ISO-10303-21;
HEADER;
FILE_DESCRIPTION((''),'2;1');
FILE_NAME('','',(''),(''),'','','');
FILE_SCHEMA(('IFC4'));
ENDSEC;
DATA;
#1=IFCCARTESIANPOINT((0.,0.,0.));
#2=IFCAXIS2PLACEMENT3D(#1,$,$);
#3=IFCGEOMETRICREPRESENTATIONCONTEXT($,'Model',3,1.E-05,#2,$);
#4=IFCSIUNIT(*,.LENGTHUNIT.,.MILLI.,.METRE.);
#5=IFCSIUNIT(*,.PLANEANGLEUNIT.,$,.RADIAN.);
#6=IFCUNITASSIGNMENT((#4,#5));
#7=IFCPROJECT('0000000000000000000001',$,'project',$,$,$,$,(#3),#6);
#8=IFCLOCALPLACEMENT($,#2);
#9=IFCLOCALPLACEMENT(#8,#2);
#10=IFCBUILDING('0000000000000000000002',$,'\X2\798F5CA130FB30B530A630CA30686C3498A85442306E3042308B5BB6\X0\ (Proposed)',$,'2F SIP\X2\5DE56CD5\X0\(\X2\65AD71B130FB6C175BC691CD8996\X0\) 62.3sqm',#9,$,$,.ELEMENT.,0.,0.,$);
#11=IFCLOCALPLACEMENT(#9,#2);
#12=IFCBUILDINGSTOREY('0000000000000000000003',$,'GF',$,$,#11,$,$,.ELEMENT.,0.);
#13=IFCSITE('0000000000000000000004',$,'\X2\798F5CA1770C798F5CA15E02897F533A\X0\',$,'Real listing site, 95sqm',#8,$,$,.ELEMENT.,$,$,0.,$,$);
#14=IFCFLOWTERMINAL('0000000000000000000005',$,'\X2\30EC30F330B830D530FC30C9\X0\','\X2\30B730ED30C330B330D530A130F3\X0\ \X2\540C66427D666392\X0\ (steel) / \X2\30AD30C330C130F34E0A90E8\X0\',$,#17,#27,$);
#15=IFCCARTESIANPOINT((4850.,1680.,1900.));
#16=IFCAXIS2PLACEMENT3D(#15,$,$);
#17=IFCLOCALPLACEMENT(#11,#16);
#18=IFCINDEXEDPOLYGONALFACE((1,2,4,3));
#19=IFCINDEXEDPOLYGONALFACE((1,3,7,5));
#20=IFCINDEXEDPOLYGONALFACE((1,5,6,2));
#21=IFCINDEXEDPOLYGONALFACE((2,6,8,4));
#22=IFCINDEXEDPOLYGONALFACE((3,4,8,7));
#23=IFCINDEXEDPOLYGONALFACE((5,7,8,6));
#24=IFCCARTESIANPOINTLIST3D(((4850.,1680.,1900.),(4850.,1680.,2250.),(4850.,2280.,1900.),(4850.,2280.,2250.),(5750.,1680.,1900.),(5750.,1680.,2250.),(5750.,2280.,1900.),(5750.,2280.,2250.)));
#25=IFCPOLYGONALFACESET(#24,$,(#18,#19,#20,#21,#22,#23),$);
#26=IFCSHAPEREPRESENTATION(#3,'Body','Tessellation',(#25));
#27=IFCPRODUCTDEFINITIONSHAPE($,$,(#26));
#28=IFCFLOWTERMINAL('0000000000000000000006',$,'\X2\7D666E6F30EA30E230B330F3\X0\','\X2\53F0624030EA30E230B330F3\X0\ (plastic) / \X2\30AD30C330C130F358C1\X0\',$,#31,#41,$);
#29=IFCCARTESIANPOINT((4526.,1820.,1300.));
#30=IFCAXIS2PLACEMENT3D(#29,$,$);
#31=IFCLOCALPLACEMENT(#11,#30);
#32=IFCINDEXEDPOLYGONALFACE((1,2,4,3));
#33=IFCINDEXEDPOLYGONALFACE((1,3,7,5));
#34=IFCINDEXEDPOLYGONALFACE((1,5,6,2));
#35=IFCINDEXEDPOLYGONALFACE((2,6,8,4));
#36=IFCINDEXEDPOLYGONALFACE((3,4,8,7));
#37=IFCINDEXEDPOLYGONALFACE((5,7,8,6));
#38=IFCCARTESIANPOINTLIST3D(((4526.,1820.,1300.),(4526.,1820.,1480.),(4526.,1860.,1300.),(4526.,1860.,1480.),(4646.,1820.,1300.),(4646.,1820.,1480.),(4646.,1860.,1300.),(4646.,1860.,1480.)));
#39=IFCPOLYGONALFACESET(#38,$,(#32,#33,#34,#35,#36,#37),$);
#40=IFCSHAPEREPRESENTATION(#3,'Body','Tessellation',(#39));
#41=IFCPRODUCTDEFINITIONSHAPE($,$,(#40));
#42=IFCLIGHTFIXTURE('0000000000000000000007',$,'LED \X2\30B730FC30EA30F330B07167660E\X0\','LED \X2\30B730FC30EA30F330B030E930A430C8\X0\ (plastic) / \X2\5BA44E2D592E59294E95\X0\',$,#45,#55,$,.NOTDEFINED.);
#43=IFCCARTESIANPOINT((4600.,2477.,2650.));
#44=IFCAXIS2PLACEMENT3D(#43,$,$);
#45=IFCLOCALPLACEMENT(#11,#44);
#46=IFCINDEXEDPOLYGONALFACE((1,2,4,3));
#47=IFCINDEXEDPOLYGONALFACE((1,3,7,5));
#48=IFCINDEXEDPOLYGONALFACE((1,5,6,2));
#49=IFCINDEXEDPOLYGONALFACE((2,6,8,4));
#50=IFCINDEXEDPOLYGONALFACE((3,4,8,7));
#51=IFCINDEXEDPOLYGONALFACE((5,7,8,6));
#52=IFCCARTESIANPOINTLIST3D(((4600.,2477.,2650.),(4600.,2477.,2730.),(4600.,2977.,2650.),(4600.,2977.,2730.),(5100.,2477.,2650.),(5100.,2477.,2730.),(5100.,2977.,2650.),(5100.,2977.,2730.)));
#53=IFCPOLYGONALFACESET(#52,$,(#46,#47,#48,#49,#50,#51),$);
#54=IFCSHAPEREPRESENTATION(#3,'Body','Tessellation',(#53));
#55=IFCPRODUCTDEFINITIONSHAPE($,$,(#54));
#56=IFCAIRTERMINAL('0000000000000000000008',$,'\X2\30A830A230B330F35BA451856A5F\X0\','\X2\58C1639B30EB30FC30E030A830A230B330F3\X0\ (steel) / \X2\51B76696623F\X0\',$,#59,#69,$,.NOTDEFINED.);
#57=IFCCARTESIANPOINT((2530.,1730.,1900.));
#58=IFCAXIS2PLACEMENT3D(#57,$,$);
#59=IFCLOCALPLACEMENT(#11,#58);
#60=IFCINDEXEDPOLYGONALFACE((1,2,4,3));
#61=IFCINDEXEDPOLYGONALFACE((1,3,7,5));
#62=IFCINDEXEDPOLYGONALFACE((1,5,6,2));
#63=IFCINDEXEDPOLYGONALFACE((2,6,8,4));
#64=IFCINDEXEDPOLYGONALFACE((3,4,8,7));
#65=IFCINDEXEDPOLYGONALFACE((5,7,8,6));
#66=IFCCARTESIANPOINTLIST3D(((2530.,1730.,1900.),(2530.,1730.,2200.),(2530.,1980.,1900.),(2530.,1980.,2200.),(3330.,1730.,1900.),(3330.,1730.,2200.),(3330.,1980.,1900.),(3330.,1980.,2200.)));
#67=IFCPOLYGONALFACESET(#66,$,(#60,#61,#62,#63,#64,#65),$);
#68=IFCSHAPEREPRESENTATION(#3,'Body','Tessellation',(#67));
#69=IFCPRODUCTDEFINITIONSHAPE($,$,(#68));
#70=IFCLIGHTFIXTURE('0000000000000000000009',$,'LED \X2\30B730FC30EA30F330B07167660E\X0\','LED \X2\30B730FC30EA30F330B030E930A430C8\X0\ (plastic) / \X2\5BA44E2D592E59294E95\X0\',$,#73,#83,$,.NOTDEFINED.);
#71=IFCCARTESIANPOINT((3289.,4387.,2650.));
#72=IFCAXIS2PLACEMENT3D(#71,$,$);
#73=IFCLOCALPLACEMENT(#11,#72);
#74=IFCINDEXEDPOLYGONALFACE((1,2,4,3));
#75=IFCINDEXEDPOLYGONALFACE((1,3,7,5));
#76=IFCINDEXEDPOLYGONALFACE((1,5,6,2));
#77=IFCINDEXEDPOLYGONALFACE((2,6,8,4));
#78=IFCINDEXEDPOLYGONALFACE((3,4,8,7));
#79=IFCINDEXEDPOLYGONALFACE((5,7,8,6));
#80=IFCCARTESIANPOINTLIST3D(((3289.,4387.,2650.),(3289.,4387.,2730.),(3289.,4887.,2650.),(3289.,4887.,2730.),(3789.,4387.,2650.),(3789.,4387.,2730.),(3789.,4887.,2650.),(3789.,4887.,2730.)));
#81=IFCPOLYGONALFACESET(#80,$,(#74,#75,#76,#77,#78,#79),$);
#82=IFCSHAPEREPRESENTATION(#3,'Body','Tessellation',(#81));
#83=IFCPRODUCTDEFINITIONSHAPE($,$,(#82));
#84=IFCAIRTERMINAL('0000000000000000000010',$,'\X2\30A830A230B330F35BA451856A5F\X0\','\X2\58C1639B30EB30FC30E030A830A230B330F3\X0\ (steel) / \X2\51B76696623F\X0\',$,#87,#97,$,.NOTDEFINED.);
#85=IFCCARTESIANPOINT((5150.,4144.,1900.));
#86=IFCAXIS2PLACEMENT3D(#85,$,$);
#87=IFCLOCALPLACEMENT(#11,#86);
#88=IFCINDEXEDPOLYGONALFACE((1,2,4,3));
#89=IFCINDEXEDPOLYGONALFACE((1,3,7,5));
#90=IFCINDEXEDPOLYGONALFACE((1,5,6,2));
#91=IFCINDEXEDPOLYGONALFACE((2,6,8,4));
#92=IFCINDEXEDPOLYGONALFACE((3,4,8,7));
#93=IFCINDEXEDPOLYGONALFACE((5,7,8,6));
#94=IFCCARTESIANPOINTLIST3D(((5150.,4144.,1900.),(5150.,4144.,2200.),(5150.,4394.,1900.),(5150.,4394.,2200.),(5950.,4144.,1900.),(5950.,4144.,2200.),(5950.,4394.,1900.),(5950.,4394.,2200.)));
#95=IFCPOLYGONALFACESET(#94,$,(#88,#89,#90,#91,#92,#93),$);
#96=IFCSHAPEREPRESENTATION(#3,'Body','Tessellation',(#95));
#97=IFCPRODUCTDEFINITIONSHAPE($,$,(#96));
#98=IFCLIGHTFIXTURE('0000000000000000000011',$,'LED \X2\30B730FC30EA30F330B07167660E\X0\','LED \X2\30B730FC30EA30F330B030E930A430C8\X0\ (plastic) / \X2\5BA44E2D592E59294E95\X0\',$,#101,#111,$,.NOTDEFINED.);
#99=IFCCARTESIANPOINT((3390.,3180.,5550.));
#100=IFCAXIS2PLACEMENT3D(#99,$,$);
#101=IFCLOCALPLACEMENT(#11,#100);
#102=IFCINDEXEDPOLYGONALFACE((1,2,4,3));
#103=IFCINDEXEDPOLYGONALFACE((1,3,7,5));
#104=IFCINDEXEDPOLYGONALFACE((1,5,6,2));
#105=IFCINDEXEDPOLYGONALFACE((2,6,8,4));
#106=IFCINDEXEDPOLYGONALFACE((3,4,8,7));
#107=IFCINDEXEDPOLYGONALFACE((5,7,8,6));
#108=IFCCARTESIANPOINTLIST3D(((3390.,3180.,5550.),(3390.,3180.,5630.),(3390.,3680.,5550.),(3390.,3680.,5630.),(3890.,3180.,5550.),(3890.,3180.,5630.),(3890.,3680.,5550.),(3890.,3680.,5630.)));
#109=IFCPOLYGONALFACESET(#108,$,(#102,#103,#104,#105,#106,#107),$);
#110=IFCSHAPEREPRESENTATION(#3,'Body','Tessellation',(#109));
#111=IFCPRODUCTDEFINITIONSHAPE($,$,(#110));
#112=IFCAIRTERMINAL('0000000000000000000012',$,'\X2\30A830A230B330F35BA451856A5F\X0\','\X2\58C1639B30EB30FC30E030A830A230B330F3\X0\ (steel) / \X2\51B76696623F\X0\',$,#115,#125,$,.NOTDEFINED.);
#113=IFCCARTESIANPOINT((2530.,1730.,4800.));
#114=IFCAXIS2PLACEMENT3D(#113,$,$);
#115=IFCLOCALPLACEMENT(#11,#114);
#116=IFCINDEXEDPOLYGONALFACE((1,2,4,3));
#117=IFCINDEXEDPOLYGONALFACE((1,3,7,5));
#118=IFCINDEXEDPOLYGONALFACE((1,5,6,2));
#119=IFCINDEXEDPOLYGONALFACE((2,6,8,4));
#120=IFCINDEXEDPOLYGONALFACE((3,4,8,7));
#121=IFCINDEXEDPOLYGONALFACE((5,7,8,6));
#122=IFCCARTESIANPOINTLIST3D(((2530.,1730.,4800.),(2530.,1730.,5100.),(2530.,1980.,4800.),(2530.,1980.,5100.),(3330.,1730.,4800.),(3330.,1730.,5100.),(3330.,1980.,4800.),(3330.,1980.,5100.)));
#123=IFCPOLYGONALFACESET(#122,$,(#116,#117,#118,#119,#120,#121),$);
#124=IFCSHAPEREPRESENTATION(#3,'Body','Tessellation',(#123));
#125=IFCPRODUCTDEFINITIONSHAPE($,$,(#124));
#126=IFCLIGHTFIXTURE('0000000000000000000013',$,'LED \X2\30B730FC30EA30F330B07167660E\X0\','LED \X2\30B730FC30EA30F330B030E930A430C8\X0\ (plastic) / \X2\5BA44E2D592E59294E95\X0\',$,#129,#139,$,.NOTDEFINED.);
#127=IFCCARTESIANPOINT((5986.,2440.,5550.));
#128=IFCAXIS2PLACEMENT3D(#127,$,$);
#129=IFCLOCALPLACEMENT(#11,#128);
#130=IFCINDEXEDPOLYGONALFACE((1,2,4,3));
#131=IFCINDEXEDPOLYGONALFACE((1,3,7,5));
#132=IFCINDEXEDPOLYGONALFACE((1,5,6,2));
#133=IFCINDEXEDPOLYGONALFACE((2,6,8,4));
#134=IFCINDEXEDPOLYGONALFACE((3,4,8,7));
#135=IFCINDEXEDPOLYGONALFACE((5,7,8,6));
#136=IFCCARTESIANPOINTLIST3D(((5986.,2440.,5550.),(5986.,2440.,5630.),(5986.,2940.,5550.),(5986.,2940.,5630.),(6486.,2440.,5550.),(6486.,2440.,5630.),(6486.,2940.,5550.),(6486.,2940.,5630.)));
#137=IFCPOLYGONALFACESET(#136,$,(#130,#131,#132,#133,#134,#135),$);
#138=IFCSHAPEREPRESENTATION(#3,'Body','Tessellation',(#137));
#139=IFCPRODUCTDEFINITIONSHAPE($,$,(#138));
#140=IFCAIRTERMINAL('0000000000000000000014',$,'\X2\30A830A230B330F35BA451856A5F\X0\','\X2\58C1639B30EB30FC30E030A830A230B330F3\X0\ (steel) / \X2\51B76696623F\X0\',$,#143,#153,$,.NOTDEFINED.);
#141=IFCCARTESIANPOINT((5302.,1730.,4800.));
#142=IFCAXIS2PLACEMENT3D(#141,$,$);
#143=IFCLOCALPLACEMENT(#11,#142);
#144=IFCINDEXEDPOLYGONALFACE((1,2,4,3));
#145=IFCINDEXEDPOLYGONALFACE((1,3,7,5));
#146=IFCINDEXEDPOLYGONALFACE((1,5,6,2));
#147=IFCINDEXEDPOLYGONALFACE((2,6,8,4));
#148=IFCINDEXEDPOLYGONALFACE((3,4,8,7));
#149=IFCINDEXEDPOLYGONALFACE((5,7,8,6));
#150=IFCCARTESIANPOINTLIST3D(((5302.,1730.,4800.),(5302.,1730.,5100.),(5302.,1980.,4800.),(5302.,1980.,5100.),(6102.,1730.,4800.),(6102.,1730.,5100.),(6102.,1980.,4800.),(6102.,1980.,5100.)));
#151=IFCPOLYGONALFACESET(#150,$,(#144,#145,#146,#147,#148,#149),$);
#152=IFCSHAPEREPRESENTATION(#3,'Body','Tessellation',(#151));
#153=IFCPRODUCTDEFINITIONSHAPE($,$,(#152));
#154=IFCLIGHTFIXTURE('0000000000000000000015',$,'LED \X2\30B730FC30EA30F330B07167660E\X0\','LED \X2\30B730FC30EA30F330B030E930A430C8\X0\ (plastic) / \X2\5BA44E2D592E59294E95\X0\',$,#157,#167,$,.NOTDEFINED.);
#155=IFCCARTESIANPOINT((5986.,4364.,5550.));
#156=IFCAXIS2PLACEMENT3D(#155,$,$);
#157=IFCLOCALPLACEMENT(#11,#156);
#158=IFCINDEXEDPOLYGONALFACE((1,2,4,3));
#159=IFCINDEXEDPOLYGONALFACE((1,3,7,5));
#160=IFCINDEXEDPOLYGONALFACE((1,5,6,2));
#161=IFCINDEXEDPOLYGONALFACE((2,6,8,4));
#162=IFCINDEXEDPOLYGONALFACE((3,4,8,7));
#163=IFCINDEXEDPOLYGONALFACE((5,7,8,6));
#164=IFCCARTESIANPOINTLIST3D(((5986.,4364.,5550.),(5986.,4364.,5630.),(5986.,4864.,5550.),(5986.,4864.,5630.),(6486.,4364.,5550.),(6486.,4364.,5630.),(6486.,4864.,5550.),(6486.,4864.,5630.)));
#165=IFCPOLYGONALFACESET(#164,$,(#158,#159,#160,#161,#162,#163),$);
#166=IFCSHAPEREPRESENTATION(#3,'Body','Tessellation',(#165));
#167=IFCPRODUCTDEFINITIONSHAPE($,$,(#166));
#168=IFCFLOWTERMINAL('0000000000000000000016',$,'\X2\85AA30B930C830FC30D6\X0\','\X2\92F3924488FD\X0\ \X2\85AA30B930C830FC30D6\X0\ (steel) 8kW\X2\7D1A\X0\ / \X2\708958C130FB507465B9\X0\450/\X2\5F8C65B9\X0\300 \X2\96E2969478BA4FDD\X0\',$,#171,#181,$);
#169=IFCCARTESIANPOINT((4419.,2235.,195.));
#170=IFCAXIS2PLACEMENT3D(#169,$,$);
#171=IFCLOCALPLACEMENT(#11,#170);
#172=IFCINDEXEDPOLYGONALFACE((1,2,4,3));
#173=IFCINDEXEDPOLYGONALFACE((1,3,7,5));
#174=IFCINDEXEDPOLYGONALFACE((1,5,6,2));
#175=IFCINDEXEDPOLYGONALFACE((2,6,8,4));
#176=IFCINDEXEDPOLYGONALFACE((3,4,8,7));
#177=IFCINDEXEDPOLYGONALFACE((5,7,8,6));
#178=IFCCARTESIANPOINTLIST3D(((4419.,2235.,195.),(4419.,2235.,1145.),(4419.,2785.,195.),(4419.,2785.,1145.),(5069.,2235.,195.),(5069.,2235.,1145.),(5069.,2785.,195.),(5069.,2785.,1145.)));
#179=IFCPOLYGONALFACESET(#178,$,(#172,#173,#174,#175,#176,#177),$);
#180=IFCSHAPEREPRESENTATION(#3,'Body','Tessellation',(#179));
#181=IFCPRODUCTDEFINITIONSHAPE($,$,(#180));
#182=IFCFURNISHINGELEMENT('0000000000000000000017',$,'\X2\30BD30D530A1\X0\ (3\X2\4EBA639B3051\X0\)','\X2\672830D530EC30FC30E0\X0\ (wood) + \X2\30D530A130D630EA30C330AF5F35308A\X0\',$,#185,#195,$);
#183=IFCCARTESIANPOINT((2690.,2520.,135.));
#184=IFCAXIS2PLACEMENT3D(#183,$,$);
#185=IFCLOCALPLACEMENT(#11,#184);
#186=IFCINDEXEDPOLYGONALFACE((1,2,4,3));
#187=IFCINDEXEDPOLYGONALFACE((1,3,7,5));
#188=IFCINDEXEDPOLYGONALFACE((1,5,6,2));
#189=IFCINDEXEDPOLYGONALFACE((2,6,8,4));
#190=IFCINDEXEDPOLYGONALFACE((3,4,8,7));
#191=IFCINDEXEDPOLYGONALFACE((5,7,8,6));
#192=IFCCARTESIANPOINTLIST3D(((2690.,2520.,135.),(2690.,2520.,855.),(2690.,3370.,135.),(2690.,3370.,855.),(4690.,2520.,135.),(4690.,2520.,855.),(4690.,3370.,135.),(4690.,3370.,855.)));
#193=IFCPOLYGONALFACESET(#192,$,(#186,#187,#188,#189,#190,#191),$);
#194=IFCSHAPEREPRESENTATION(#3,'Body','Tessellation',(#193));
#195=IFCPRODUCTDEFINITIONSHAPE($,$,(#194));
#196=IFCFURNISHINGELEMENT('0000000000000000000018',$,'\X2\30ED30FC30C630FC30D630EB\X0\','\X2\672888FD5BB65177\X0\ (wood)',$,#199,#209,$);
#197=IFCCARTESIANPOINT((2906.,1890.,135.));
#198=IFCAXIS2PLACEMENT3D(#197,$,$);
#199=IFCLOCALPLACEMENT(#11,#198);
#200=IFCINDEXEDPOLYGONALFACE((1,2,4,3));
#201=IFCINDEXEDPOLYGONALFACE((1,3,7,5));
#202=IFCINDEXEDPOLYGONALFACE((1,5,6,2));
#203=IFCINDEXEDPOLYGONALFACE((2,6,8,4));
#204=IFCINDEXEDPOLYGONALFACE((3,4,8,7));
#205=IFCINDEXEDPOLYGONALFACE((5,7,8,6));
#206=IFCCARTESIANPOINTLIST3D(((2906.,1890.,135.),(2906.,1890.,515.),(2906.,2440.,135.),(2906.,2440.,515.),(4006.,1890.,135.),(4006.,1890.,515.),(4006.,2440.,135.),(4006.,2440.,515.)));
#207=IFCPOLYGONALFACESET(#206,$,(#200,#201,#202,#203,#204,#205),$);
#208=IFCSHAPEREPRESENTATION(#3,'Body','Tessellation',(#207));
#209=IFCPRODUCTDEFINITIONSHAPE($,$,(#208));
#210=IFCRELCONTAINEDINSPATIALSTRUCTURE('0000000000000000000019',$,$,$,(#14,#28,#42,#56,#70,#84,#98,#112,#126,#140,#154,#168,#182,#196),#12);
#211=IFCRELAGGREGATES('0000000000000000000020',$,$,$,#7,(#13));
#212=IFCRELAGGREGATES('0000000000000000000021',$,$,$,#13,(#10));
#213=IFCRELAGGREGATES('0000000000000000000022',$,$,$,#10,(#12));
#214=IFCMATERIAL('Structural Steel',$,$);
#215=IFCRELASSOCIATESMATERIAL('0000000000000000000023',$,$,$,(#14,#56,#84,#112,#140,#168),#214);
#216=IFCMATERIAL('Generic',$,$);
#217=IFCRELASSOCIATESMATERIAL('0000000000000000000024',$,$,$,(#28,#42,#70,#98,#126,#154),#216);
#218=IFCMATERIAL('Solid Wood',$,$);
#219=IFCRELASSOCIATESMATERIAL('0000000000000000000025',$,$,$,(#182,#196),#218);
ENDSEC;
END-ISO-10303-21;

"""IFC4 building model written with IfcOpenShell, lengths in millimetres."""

from ifc_helpers import new_model, si_unit, frame, frame_2d, origin, place, context, project, spatial, rectangle, extrude, material, element, save


model = new_model("IFC4")

# Units and contexts
model_context = context("Model", 3, precision=1e-05, world=origin())
ifc_project = project(units=[si_unit("LENGTHUNIT", "METRE", prefix="MILLI"), si_unit("PLANEANGLEUNIT", "RADIAN")], contexts=[model_context])

# Site, building, storey
site_placement = place(None, origin())
site = spatial("IfcSite", under=ifc_project, at=site_placement, Name="福岡県福岡市西区", ObjectType="Real listing site, 95sqm", CompositionType="ELEMENT", RefElevation=0.0)
building_placement = place(site_placement, origin())
building = spatial("IfcBuilding", under=site, at=building_placement, Name="福岡・サウナと水風呂のある家 (Proposed)", ObjectType="2F SIP工法(断熱・気密重視) 62.3sqm", CompositionType="ELEMENT", ElevationOfRefHeight=0.0, ElevationOfTerrain=0.0)
storey_placement = place(building_placement, origin())
storey = spatial("IfcBuildingStorey", under=building, at=storey_placement, Name="GF", CompositionType="ELEMENT", Elevation=0.0)

# Shared definitions
ifc_material_1 = material(Name="Solid Wood")

# Shared definitions
ifc_material_2 = material(Name="Structural Steel")

# Flow terminals
flow_terminal_1_placement = place(storey_placement, frame((4850.0, 1680.0, 1900.0)))
element("IfcFlowTerminal", 1, at=flow_terminal_1_placement, inside=storey, material=ifc_material_2, Name="レンジフード", Description="シロッコファン 同時給排 (steel) / キッチン上部", context=model_context, shape_type="SweptSolid", body=[
    extrude(rectangle(XDim=900.0, YDim=600.0, at=frame_2d((450.0, 300.0))), frame((4850.0, 1680.0, 1900.0)), (0.0, 0.0, 1.0), 350.0),
])
ifc_material_3 = material(Name="Generic")
flow_terminal_2_placement = place(storey_placement, frame((4526.0, 1820.0, 1300.0)))
element("IfcFlowTerminal", 2, at=flow_terminal_2_placement, inside=storey, material=ifc_material_3, Name="給湯リモコン", Description="台所リモコン (plastic) / キッチン壁", context=model_context, shape_type="SweptSolid", body=[
    extrude(rectangle(XDim=120.0, YDim=40.0, at=frame_2d((60.0, 20.0))), frame((4526.0, 1820.0, 1300.0)), (0.0, 0.0, 1.0), 180.0),
])

# Light fixture
light_fixture_1_placement = place(storey_placement, frame((4600.0, 2477.0, 2650.0)))
element("IfcLightFixture", 3, at=light_fixture_1_placement, inside=storey, material=ifc_material_3, Name="LED シーリング照明", Description="LED シーリングライト (plastic) / 室中央天井", PredefinedType="NOTDEFINED", context=model_context, shape_type="SweptSolid", body=[
    extrude(rectangle(XDim=500.0, YDim=500.0, at=frame_2d((250.0, 250.0))), frame((4600.0, 2477.0, 2650.0)), (0.0, 0.0, 1.0), 80.0),
])

# Air terminal
air_terminal_1_placement = place(storey_placement, frame((2530.0, 1730.0, 1900.0)))
element("IfcAirTerminal", 4, at=air_terminal_1_placement, inside=storey, material=ifc_material_2, Name="エアコン室内機", Description="壁掛ルームエアコン (steel) / 冷暖房", PredefinedType="NOTDEFINED", context=model_context, shape_type="SweptSolid", body=[
    extrude(rectangle(XDim=800.0, YDim=250.0, at=frame_2d((400.0, 125.0))), frame((2530.0, 1730.0, 1900.0)), (0.0, 0.0, 1.0), 300.0),
])

# Light fixture
light_fixture_2_placement = place(storey_placement, frame((3289.0, 4387.0, 2650.0)))
element("IfcLightFixture", 5, at=light_fixture_2_placement, inside=storey, material=ifc_material_3, Name="LED シーリング照明", Description="LED シーリングライト (plastic) / 室中央天井", PredefinedType="NOTDEFINED", context=model_context, shape_type="SweptSolid", body=[
    extrude(rectangle(XDim=500.0, YDim=500.0, at=frame_2d((250.0, 250.0))), frame((3289.0, 4387.0, 2650.0)), (0.0, 0.0, 1.0), 80.0),
])

# Air terminal
air_terminal_2_placement = place(storey_placement, frame((5150.0, 4144.0, 1900.0)))
element("IfcAirTerminal", 6, at=air_terminal_2_placement, inside=storey, material=ifc_material_2, Name="エアコン室内機", Description="壁掛ルームエアコン (steel) / 冷暖房", PredefinedType="NOTDEFINED", context=model_context, shape_type="SweptSolid", body=[
    extrude(rectangle(XDim=800.0, YDim=250.0, at=frame_2d((400.0, 125.0))), frame((5150.0, 4144.0, 1900.0)), (0.0, 0.0, 1.0), 300.0),
])

# Light fixture
light_fixture_3_placement = place(storey_placement, frame((3390.0, 3180.0, 5550.0)))
element("IfcLightFixture", 7, at=light_fixture_3_placement, inside=storey, material=ifc_material_3, Name="LED シーリング照明", Description="LED シーリングライト (plastic) / 室中央天井", PredefinedType="NOTDEFINED", context=model_context, shape_type="SweptSolid", body=[
    extrude(rectangle(XDim=500.0, YDim=500.0, at=frame_2d((250.0, 250.0))), frame((3390.0, 3180.0, 5550.0)), (0.0, 0.0, 1.0), 80.0),
])

# Air terminal
air_terminal_3_placement = place(storey_placement, frame((2530.0, 1730.0, 4800.0)))
element("IfcAirTerminal", 8, at=air_terminal_3_placement, inside=storey, material=ifc_material_2, Name="エアコン室内機", Description="壁掛ルームエアコン (steel) / 冷暖房", PredefinedType="NOTDEFINED", context=model_context, shape_type="SweptSolid", body=[
    extrude(rectangle(XDim=800.0, YDim=250.0, at=frame_2d((400.0, 125.0))), frame((2530.0, 1730.0, 4800.0)), (0.0, 0.0, 1.0), 300.0),
])

# Light fixture
light_fixture_4_placement = place(storey_placement, frame((5986.0, 2440.0, 5550.0)))
element("IfcLightFixture", 9, at=light_fixture_4_placement, inside=storey, material=ifc_material_3, Name="LED シーリング照明", Description="LED シーリングライト (plastic) / 室中央天井", PredefinedType="NOTDEFINED", context=model_context, shape_type="SweptSolid", body=[
    extrude(rectangle(XDim=500.0, YDim=500.0, at=frame_2d((250.0, 250.0))), frame((5986.0, 2440.0, 5550.0)), (0.0, 0.0, 1.0), 80.0),
])

# Air terminal
air_terminal_4_placement = place(storey_placement, frame((5302.0, 1730.0, 4800.0)))
element("IfcAirTerminal", 10, at=air_terminal_4_placement, inside=storey, material=ifc_material_2, Name="エアコン室内機", Description="壁掛ルームエアコン (steel) / 冷暖房", PredefinedType="NOTDEFINED", context=model_context, shape_type="SweptSolid", body=[
    extrude(rectangle(XDim=800.0, YDim=250.0, at=frame_2d((400.0, 125.0))), frame((5302.0, 1730.0, 4800.0)), (0.0, 0.0, 1.0), 300.0),
])

# Light fixture
light_fixture_5_placement = place(storey_placement, frame((5986.0, 4364.0, 5550.0)))
element("IfcLightFixture", 11, at=light_fixture_5_placement, inside=storey, material=ifc_material_3, Name="LED シーリング照明", Description="LED シーリングライト (plastic) / 室中央天井", PredefinedType="NOTDEFINED", context=model_context, shape_type="SweptSolid", body=[
    extrude(rectangle(XDim=500.0, YDim=500.0, at=frame_2d((250.0, 250.0))), frame((5986.0, 4364.0, 5550.0)), (0.0, 0.0, 1.0), 80.0),
])

# Flow terminal
flow_terminal_3_placement = place(storey_placement, frame((4419.0, 2235.0, 195.0)))
element("IfcFlowTerminal", 12, at=flow_terminal_3_placement, inside=storey, material=ifc_material_2, Name="薪ストーブ", Description="鋳鉄製 薪ストーブ (steel) 8kW級 / 炉壁・側方450/後方300 離隔確保", context=model_context, shape_type="SweptSolid", body=[
    extrude(rectangle(XDim=650.0, YDim=550.0, at=frame_2d((325.0, 275.0))), frame((4419.0, 2235.0, 195.0)), (0.0, 0.0, 1.0), 950.0),
])

# Furnishing elements
furnishing_1_placement = place(storey_placement, frame((2690.0, 2520.0, 135.0)))
element("IfcFurnishingElement", 13, at=furnishing_1_placement, inside=storey, material=ifc_material_1, Name="ソファ (3人掛け)", Description="木フレーム (wood) + ファブリック張り", context=model_context, shape_type="SweptSolid", body=[
    extrude(rectangle(XDim=2000.0, YDim=850.0, at=frame_2d((1000.0, 425.0))), frame((2690.0, 2520.0, 135.0)), (0.0, 0.0, 1.0), 720.0),
])
furnishing_2_placement = place(storey_placement, frame((2906.0, 1890.0, 135.0)))
element("IfcFurnishingElement", 14, at=furnishing_2_placement, inside=storey, material=ifc_material_1, Name="ローテーブル", Description="木製家具 (wood)", context=model_context, shape_type="SweptSolid", body=[
    extrude(rectangle(XDim=1100.0, YDim=550.0, at=frame_2d((550.0, 275.0))), frame((2906.0, 1890.0, 135.0)), (0.0, 0.0, 1.0), 380.0),
])

save(model, "model.ifc")
